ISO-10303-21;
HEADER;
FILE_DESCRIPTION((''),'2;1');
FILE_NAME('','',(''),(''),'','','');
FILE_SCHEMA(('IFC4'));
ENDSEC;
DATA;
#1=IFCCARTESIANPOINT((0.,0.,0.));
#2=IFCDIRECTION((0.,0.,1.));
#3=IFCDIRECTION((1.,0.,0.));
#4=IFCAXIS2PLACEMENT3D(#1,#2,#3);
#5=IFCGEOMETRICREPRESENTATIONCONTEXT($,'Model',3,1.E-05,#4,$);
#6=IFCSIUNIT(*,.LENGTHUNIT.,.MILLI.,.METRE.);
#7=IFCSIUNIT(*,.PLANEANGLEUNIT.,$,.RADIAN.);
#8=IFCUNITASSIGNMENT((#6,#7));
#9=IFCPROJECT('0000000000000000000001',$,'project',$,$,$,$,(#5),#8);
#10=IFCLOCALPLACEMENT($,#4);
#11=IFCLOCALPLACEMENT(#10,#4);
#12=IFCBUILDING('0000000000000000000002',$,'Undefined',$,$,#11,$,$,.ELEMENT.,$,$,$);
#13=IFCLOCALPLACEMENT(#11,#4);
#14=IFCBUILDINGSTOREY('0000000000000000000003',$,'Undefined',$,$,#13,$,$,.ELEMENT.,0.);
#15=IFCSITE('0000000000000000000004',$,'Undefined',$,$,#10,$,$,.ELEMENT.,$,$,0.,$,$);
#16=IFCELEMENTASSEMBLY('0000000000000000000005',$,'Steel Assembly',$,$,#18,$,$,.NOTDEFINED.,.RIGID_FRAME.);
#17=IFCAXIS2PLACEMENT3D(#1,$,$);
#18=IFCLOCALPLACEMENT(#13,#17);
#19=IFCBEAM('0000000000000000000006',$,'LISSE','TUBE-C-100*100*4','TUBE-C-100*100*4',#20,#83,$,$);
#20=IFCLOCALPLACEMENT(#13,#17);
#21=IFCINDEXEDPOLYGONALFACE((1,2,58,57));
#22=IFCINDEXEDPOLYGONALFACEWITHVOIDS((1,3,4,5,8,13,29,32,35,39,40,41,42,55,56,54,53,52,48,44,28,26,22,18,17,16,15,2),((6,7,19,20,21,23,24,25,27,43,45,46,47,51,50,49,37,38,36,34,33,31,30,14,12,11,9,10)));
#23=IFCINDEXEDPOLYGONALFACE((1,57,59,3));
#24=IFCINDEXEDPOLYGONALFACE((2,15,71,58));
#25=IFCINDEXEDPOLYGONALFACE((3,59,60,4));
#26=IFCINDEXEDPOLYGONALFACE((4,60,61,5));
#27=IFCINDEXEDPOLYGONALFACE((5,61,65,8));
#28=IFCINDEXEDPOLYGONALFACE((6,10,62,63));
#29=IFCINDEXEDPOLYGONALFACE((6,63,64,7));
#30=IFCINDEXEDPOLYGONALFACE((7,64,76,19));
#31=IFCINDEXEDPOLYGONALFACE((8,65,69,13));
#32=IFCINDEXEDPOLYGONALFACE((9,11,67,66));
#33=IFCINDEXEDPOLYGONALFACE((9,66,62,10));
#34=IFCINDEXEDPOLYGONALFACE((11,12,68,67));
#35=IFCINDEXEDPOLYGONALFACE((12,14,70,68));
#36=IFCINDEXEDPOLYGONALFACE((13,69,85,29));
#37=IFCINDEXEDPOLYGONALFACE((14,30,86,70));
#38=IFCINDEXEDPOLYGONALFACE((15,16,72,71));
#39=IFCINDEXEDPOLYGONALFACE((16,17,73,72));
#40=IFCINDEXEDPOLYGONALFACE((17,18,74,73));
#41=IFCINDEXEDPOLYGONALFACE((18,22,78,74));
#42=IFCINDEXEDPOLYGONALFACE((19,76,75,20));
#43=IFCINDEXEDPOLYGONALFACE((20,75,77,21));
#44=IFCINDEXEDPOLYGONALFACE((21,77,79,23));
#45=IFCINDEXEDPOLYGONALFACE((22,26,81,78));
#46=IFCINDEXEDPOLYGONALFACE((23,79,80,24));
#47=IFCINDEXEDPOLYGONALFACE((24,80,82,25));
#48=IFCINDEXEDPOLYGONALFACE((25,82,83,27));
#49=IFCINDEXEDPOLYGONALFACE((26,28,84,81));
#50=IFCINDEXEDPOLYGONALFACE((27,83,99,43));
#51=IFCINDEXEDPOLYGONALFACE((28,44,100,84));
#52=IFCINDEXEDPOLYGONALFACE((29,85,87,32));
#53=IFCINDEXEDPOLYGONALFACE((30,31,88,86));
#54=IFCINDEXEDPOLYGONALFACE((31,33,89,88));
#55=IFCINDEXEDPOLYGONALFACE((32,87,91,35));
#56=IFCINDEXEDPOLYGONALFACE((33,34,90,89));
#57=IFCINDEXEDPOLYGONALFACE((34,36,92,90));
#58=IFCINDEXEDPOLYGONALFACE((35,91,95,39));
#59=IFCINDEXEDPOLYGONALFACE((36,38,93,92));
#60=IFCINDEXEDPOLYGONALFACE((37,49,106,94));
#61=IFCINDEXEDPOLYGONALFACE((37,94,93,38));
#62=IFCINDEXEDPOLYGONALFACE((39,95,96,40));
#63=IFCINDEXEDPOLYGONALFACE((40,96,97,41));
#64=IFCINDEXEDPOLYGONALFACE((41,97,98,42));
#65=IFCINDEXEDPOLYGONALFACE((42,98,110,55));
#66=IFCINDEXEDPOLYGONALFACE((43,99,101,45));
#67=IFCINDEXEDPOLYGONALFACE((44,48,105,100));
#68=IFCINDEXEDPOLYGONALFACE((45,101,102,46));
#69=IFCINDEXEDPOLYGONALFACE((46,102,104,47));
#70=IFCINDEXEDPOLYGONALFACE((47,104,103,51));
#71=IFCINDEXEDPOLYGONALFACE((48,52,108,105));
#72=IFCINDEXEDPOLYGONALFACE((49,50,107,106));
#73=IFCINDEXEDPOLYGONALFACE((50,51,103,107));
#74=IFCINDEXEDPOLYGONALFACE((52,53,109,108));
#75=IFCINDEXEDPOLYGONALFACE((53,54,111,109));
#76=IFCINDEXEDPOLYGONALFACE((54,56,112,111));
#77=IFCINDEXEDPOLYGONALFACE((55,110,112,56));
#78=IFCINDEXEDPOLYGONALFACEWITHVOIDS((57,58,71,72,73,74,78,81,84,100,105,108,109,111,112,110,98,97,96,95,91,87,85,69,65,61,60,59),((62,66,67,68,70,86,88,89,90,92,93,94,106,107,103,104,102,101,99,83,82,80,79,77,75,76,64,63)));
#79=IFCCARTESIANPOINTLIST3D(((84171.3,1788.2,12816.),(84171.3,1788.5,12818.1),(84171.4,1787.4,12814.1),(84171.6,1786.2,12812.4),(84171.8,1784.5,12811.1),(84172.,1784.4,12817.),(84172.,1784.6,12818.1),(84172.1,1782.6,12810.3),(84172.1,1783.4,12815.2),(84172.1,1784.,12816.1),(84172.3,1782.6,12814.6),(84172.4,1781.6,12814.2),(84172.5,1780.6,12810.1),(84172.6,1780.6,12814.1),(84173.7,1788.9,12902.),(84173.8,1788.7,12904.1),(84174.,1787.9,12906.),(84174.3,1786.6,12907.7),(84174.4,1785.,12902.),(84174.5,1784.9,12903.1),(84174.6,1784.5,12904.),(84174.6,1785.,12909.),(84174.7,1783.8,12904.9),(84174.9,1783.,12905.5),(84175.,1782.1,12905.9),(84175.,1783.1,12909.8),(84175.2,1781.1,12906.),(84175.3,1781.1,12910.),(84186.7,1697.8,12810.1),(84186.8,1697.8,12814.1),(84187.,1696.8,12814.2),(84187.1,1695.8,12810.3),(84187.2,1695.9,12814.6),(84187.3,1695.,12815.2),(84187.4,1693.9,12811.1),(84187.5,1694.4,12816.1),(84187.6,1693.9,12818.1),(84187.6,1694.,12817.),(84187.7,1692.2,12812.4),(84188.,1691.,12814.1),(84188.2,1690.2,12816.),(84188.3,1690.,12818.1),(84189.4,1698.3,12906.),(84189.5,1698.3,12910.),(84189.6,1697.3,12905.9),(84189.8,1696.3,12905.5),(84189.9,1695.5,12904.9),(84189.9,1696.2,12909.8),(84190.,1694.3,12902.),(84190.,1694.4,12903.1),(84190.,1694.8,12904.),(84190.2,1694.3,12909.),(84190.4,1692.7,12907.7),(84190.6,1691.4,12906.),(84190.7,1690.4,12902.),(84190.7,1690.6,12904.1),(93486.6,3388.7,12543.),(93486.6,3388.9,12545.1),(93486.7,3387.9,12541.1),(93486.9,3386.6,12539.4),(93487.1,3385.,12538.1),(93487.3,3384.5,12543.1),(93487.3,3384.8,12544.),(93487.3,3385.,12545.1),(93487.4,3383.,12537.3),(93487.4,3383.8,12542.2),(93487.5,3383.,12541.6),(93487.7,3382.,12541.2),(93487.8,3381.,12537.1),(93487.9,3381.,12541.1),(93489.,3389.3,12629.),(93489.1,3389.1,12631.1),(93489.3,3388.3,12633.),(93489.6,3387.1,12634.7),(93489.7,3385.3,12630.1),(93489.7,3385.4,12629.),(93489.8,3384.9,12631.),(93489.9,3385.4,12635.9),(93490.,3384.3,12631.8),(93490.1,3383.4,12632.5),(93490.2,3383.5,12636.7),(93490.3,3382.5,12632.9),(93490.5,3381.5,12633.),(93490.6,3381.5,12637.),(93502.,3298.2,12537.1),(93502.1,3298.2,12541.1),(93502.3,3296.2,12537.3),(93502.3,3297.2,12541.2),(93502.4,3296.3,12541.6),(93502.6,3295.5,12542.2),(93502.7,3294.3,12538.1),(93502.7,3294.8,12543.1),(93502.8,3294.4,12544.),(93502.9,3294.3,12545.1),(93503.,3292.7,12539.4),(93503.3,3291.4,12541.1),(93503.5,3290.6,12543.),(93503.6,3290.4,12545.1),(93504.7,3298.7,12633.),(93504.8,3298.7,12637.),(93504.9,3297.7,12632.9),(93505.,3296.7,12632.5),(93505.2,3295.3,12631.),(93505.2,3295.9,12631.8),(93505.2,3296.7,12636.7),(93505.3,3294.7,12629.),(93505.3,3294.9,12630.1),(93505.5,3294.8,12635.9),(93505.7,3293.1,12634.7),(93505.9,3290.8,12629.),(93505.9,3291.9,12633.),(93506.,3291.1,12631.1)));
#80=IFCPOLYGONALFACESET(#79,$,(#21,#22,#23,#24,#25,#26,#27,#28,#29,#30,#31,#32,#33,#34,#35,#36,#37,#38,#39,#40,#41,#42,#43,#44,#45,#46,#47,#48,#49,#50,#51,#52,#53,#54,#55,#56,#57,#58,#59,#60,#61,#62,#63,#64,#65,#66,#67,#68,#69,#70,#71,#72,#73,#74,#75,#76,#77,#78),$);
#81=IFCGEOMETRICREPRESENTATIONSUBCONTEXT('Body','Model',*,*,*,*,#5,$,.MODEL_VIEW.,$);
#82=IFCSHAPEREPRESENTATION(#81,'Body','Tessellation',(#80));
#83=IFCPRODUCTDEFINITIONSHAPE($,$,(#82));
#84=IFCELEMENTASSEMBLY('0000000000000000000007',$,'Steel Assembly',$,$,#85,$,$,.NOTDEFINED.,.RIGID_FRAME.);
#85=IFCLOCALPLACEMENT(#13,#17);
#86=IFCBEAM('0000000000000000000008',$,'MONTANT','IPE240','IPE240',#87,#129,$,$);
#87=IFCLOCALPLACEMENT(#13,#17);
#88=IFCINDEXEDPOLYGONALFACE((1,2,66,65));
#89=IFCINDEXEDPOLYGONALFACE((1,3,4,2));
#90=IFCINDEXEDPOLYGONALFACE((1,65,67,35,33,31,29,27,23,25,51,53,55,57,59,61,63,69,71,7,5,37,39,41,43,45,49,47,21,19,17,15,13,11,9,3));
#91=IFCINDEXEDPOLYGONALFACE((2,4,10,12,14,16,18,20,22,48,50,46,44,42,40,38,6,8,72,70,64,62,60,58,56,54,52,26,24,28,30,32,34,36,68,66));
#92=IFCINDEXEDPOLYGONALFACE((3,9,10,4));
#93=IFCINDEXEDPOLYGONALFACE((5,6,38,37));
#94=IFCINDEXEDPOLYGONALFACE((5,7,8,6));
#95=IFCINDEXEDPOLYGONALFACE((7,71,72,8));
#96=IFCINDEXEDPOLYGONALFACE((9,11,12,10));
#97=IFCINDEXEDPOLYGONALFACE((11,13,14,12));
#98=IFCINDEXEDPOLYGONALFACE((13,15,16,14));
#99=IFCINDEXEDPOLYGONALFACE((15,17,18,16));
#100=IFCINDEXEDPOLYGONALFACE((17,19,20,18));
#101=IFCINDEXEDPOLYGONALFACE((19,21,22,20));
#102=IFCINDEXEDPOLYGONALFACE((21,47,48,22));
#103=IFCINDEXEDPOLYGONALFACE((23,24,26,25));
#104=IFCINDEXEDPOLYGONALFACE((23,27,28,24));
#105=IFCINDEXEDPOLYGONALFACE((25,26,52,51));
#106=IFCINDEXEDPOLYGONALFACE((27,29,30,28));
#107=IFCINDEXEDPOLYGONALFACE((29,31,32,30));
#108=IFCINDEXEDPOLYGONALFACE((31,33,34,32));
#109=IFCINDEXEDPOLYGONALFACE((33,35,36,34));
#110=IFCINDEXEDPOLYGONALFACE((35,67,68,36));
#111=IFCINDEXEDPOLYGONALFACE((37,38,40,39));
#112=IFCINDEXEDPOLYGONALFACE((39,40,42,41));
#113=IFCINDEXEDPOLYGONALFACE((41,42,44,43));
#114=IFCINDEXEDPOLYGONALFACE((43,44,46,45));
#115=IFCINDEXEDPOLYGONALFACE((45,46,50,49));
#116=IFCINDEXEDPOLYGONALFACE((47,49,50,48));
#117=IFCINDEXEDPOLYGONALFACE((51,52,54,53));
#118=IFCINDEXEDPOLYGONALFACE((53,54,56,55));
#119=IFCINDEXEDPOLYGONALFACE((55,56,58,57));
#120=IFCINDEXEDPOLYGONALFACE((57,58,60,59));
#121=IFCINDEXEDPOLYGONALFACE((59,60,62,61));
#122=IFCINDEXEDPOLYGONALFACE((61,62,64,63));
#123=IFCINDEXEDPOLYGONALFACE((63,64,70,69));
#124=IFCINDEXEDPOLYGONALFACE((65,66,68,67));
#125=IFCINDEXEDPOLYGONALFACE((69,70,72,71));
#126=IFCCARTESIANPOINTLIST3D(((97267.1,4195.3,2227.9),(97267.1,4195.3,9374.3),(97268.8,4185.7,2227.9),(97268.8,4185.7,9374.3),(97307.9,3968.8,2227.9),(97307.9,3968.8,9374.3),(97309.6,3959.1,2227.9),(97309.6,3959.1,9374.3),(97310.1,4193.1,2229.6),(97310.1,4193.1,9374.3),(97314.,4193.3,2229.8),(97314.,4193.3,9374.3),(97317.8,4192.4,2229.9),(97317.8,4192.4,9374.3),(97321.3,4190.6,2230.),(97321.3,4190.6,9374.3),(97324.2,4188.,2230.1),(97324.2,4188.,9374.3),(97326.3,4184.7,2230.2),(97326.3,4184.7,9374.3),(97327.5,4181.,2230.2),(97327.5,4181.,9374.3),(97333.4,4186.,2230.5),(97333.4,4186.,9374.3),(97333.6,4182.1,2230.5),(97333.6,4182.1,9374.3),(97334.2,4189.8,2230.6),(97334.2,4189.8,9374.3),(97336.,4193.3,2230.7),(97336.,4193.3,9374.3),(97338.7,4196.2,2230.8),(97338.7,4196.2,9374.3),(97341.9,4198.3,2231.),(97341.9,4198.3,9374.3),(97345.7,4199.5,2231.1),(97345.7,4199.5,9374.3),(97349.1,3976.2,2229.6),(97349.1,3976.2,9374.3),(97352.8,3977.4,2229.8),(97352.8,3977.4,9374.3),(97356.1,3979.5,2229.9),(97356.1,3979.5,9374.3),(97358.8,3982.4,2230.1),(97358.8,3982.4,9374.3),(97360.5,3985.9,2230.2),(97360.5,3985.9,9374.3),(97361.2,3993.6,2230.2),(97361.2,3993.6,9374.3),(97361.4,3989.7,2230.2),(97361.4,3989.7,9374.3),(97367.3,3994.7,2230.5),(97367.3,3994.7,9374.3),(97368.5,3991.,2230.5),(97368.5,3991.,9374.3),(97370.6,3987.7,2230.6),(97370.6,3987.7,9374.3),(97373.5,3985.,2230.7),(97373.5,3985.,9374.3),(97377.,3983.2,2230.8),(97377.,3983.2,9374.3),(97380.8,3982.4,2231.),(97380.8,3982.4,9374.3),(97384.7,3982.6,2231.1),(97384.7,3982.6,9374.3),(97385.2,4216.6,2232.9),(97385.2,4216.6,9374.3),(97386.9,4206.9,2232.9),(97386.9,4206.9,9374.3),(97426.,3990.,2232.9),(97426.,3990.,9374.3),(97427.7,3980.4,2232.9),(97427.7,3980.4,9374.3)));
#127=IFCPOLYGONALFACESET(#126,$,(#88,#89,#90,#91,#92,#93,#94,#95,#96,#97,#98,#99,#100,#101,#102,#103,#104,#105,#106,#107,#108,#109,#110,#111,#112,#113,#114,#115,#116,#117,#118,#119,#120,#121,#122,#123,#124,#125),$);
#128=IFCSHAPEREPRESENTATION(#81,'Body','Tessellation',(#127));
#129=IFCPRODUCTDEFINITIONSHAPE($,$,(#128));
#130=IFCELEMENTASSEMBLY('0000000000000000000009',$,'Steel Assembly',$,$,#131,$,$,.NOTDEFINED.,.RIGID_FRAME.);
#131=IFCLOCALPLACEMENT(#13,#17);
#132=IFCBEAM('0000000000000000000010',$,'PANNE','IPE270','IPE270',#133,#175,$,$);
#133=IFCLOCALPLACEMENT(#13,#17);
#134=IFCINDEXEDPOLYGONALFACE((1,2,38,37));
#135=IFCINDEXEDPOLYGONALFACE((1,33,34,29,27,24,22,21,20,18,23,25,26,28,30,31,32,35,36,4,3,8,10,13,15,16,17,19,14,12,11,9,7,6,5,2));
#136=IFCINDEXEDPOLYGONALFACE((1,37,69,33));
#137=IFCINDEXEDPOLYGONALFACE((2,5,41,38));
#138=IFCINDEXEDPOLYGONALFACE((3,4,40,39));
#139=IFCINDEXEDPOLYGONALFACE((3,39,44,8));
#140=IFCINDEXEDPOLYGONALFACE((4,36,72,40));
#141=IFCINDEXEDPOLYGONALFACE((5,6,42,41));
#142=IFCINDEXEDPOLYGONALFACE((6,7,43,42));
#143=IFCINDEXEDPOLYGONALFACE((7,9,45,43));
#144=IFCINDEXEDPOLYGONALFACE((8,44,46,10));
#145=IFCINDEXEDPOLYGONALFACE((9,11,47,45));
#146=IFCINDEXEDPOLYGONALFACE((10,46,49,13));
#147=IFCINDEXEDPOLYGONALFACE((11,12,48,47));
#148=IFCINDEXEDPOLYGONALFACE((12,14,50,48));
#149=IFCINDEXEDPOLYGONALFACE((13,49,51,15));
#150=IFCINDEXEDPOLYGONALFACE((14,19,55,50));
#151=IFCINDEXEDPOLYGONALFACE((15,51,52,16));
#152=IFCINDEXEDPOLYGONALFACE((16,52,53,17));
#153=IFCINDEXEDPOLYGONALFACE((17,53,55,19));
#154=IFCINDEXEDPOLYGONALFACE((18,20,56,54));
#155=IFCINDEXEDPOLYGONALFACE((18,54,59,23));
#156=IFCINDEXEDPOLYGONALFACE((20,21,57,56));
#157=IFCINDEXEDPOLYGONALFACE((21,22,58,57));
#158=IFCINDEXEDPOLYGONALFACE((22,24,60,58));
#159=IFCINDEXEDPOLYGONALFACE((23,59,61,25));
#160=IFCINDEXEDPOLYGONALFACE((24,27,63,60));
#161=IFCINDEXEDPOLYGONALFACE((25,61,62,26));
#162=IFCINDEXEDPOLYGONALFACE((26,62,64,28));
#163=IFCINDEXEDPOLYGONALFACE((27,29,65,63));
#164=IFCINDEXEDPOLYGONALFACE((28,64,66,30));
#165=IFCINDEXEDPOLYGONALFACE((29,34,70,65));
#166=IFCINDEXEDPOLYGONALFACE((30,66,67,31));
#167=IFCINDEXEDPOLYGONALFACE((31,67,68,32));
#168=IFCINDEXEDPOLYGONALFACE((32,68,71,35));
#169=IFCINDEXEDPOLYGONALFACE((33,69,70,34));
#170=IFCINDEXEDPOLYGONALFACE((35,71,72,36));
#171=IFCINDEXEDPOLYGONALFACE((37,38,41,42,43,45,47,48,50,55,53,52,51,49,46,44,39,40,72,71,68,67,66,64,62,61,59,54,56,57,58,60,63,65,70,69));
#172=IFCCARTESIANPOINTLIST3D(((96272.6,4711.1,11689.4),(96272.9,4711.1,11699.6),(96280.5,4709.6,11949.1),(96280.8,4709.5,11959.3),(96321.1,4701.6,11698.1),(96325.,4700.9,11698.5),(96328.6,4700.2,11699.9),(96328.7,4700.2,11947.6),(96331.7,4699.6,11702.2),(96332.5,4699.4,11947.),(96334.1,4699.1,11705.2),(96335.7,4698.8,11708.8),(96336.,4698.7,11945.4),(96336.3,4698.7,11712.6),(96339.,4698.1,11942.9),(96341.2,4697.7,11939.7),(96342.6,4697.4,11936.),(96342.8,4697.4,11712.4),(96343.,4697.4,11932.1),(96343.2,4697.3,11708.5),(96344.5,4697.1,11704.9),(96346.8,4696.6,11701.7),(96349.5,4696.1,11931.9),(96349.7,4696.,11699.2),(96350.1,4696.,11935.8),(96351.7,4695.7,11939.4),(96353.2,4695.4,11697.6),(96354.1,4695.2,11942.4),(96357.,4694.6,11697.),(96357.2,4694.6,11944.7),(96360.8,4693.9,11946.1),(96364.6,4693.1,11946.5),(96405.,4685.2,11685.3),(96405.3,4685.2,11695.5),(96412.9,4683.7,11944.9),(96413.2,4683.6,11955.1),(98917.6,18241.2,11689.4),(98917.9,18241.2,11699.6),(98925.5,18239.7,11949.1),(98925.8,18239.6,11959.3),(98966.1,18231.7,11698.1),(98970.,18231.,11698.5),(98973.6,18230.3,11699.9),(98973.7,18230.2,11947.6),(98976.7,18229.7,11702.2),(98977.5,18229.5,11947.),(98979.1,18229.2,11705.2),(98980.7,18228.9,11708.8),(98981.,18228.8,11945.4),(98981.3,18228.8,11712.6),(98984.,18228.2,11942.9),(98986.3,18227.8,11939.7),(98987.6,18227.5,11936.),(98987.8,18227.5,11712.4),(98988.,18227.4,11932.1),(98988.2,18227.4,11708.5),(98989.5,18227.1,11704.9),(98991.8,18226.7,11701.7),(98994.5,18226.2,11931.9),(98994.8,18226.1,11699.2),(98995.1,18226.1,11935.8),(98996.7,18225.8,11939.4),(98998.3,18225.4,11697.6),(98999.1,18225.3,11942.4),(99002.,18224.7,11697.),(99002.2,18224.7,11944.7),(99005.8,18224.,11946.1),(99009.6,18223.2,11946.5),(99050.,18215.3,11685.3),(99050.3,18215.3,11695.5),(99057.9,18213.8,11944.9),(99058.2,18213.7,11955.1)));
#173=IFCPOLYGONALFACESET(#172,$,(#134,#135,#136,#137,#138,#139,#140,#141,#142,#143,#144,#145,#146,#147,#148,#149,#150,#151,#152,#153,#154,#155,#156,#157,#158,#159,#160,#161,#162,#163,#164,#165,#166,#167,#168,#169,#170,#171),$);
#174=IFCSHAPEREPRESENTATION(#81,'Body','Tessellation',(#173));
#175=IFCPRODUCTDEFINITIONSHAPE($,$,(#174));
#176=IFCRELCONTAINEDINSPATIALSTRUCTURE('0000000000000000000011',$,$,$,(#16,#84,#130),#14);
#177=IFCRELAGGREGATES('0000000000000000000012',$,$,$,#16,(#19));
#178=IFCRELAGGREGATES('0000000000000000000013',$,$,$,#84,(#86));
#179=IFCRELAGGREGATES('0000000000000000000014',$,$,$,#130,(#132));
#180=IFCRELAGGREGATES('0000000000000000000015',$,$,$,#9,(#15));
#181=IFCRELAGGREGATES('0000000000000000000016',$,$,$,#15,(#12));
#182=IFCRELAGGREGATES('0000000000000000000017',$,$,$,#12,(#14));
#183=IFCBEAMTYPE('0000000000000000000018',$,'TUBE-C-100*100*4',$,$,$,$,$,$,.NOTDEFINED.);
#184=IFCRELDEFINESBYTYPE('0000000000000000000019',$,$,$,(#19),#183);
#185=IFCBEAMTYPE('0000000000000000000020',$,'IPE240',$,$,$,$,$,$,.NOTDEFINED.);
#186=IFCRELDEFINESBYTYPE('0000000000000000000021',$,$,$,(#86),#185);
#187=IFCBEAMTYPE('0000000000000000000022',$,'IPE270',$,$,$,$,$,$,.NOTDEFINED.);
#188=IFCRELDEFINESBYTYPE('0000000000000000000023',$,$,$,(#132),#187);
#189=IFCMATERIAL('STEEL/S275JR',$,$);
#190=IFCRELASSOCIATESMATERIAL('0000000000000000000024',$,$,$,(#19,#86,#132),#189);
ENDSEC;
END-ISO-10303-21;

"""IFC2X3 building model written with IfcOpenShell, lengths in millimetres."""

from ifc_helpers import new_model, si_unit, frame, origin_with_axes, origin_2d_with_axis, place, context, subcontext, project, spatial, hollow_rectangle, i_section, extrude, clip, halfspace, material, type_object, element, aggregate, save


model = new_model("IFC2X3")

# Units and contexts
model_context = context("Model", 3, precision=1e-05, world=origin_with_axes())
body_context = subcontext(model_context, "Body", "Model", "MODEL_VIEW")
ifc_project = project(units=[si_unit("LENGTHUNIT", "METRE", prefix="MILLI"), si_unit("PLANEANGLEUNIT", "RADIAN")], contexts=[model_context])

# Site, building, storey
site_placement = place(None, origin_with_axes())
site = spatial("IfcSite", under=ifc_project, at=site_placement, Name="Undefined", CompositionType="ELEMENT", RefElevation=0.0)
building_placement = place(site_placement, origin_with_axes())
building = spatial("IfcBuilding", under=site, at=building_placement, Name="Undefined", CompositionType="ELEMENT")
storey_placement = place(building_placement, origin_with_axes())
storey = spatial("IfcBuildingStorey", under=building, at=storey_placement, Name="Undefined", CompositionType="ELEMENT", Elevation=0.0)

# Element assemblies, beams
assembly_1_placement = place(storey_placement, origin_with_axes())
assembly_1 = element("IfcElementAssembly", 1, at=assembly_1_placement, inside=storey, Name="Steel Assembly", AssemblyPlace="NOTDEFINED", PredefinedType="RIGID_FRAME")
ifc_material = material(Name="STEEL/S275JR")
beam_type_1 = type_object("IfcBeamType", Name="TUBE-C-100*100*4", PredefinedType="NOTDEFINED")
beam_1_placement = place(assembly_1_placement, frame((93496.3, 3339.9, 12587.0), z_axis=(0.028456, 0.004889, 0.999583), x_axis=(-0.985149, -0.169254, 0.028873)))
beam_1 = element("IfcBeam", 2, at=beam_1_placement, type_object=beam_type_1, material=ifc_material, Name="LISSE", Description="TUBE-C-100*100*4", ObjectType="TUBE-C-100*100*4", context=body_context, shape_type="SweptSolid", body=[
    extrude(hollow_rectangle(XDim=100.0, YDim=100.0, WallThickness=4.0, InnerFilletRadius=4.0, OuterFilletRadius=8.0, at=origin_2d_with_axis()), frame((9455.7, 0.0, 0.0), z_axis=(-1.0, 0.0, 0.0), x_axis=(0.0, -1.0, 0.0)), (0.0, 0.0, 1.0), 9455.7),
])
aggregate(assembly_1, [beam_1])
assembly_2_placement = place(storey_placement, origin_with_axes())
assembly_2 = element("IfcElementAssembly", 3, at=assembly_2_placement, inside=storey, Name="Steel Assembly", AssemblyPlace="NOTDEFINED", PredefinedType="RIGID_FRAME")
beam_type_2 = type_object("IfcBeamType", Name="IPE240", PredefinedType="NOTDEFINED")
beam_2_placement = place(assembly_2_placement, frame((97347.4, 4087.8, 9374.3), z_axis=(-0.177139, 0.984186, 0.0), x_axis=(0.0, 0.0, -1.0)))
beam_2 = element("IfcBeam", 4, at=beam_2_placement, type_object=beam_type_2, material=ifc_material, Name="MONTANT", Description="IPE240", ObjectType="IPE240", context=body_context, shape_type="Clipping", body=[
    clip(extrude(i_section(OverallWidth=120.0, OverallDepth=240.0, WebThickness=6.2, FlangeThickness=9.8, FilletRadius=15.0, at=origin_2d_with_axis()), frame((7146.5, 0.0, 0.0), z_axis=(-1.0, 0.0, 0.0), x_axis=(0.0, -1.0, 0.0)), (0.0, 0.0, 1.0), 7146.5), halfspace(frame((7147.9, 93.6, -109.0), z_axis=(-0.999135, 0.041596, 0.000021), x_axis=(0.0, -0.000512, 1.0)), True)),
])
aggregate(assembly_2, [beam_2])
assembly_3_placement = place(storey_placement, origin_with_axes())
assembly_3 = element("IfcElementAssembly", 5, at=assembly_3_placement, inside=storey, Name="Steel Assembly", AssemblyPlace="NOTDEFINED", PredefinedType="RIGID_FRAME")
beam_type_3 = type_object("IfcBeamType", Name="IPE270", PredefinedType="NOTDEFINED")
beam_3_placement = place(assembly_3_placement, frame((96342.9, 4697.4, 11822.3), z_axis=(0.030408, -0.005945, 0.99952), x_axis=(0.191859, 0.981422, 0.0)))
beam_3 = element("IfcBeam", 6, at=beam_3_placement, type_object=beam_type_3, material=ifc_material, Name="PANNE", Description="IPE270", ObjectType="IPE270", context=body_context, shape_type="SweptSolid", body=[
    extrude(i_section(OverallWidth=135.0, OverallDepth=270.0, WebThickness=6.6, FlangeThickness=10.2, FilletRadius=15.0, at=origin_2d_with_axis()), frame((13786.2, 0.0, 0.0), z_axis=(-1.0, 0.0, 0.0), x_axis=(0.0, -1.0, 0.0)), (0.0, 0.0, 1.0), 13786.2),
])
aggregate(assembly_3, [beam_3])

save(model, "model.ifc")
